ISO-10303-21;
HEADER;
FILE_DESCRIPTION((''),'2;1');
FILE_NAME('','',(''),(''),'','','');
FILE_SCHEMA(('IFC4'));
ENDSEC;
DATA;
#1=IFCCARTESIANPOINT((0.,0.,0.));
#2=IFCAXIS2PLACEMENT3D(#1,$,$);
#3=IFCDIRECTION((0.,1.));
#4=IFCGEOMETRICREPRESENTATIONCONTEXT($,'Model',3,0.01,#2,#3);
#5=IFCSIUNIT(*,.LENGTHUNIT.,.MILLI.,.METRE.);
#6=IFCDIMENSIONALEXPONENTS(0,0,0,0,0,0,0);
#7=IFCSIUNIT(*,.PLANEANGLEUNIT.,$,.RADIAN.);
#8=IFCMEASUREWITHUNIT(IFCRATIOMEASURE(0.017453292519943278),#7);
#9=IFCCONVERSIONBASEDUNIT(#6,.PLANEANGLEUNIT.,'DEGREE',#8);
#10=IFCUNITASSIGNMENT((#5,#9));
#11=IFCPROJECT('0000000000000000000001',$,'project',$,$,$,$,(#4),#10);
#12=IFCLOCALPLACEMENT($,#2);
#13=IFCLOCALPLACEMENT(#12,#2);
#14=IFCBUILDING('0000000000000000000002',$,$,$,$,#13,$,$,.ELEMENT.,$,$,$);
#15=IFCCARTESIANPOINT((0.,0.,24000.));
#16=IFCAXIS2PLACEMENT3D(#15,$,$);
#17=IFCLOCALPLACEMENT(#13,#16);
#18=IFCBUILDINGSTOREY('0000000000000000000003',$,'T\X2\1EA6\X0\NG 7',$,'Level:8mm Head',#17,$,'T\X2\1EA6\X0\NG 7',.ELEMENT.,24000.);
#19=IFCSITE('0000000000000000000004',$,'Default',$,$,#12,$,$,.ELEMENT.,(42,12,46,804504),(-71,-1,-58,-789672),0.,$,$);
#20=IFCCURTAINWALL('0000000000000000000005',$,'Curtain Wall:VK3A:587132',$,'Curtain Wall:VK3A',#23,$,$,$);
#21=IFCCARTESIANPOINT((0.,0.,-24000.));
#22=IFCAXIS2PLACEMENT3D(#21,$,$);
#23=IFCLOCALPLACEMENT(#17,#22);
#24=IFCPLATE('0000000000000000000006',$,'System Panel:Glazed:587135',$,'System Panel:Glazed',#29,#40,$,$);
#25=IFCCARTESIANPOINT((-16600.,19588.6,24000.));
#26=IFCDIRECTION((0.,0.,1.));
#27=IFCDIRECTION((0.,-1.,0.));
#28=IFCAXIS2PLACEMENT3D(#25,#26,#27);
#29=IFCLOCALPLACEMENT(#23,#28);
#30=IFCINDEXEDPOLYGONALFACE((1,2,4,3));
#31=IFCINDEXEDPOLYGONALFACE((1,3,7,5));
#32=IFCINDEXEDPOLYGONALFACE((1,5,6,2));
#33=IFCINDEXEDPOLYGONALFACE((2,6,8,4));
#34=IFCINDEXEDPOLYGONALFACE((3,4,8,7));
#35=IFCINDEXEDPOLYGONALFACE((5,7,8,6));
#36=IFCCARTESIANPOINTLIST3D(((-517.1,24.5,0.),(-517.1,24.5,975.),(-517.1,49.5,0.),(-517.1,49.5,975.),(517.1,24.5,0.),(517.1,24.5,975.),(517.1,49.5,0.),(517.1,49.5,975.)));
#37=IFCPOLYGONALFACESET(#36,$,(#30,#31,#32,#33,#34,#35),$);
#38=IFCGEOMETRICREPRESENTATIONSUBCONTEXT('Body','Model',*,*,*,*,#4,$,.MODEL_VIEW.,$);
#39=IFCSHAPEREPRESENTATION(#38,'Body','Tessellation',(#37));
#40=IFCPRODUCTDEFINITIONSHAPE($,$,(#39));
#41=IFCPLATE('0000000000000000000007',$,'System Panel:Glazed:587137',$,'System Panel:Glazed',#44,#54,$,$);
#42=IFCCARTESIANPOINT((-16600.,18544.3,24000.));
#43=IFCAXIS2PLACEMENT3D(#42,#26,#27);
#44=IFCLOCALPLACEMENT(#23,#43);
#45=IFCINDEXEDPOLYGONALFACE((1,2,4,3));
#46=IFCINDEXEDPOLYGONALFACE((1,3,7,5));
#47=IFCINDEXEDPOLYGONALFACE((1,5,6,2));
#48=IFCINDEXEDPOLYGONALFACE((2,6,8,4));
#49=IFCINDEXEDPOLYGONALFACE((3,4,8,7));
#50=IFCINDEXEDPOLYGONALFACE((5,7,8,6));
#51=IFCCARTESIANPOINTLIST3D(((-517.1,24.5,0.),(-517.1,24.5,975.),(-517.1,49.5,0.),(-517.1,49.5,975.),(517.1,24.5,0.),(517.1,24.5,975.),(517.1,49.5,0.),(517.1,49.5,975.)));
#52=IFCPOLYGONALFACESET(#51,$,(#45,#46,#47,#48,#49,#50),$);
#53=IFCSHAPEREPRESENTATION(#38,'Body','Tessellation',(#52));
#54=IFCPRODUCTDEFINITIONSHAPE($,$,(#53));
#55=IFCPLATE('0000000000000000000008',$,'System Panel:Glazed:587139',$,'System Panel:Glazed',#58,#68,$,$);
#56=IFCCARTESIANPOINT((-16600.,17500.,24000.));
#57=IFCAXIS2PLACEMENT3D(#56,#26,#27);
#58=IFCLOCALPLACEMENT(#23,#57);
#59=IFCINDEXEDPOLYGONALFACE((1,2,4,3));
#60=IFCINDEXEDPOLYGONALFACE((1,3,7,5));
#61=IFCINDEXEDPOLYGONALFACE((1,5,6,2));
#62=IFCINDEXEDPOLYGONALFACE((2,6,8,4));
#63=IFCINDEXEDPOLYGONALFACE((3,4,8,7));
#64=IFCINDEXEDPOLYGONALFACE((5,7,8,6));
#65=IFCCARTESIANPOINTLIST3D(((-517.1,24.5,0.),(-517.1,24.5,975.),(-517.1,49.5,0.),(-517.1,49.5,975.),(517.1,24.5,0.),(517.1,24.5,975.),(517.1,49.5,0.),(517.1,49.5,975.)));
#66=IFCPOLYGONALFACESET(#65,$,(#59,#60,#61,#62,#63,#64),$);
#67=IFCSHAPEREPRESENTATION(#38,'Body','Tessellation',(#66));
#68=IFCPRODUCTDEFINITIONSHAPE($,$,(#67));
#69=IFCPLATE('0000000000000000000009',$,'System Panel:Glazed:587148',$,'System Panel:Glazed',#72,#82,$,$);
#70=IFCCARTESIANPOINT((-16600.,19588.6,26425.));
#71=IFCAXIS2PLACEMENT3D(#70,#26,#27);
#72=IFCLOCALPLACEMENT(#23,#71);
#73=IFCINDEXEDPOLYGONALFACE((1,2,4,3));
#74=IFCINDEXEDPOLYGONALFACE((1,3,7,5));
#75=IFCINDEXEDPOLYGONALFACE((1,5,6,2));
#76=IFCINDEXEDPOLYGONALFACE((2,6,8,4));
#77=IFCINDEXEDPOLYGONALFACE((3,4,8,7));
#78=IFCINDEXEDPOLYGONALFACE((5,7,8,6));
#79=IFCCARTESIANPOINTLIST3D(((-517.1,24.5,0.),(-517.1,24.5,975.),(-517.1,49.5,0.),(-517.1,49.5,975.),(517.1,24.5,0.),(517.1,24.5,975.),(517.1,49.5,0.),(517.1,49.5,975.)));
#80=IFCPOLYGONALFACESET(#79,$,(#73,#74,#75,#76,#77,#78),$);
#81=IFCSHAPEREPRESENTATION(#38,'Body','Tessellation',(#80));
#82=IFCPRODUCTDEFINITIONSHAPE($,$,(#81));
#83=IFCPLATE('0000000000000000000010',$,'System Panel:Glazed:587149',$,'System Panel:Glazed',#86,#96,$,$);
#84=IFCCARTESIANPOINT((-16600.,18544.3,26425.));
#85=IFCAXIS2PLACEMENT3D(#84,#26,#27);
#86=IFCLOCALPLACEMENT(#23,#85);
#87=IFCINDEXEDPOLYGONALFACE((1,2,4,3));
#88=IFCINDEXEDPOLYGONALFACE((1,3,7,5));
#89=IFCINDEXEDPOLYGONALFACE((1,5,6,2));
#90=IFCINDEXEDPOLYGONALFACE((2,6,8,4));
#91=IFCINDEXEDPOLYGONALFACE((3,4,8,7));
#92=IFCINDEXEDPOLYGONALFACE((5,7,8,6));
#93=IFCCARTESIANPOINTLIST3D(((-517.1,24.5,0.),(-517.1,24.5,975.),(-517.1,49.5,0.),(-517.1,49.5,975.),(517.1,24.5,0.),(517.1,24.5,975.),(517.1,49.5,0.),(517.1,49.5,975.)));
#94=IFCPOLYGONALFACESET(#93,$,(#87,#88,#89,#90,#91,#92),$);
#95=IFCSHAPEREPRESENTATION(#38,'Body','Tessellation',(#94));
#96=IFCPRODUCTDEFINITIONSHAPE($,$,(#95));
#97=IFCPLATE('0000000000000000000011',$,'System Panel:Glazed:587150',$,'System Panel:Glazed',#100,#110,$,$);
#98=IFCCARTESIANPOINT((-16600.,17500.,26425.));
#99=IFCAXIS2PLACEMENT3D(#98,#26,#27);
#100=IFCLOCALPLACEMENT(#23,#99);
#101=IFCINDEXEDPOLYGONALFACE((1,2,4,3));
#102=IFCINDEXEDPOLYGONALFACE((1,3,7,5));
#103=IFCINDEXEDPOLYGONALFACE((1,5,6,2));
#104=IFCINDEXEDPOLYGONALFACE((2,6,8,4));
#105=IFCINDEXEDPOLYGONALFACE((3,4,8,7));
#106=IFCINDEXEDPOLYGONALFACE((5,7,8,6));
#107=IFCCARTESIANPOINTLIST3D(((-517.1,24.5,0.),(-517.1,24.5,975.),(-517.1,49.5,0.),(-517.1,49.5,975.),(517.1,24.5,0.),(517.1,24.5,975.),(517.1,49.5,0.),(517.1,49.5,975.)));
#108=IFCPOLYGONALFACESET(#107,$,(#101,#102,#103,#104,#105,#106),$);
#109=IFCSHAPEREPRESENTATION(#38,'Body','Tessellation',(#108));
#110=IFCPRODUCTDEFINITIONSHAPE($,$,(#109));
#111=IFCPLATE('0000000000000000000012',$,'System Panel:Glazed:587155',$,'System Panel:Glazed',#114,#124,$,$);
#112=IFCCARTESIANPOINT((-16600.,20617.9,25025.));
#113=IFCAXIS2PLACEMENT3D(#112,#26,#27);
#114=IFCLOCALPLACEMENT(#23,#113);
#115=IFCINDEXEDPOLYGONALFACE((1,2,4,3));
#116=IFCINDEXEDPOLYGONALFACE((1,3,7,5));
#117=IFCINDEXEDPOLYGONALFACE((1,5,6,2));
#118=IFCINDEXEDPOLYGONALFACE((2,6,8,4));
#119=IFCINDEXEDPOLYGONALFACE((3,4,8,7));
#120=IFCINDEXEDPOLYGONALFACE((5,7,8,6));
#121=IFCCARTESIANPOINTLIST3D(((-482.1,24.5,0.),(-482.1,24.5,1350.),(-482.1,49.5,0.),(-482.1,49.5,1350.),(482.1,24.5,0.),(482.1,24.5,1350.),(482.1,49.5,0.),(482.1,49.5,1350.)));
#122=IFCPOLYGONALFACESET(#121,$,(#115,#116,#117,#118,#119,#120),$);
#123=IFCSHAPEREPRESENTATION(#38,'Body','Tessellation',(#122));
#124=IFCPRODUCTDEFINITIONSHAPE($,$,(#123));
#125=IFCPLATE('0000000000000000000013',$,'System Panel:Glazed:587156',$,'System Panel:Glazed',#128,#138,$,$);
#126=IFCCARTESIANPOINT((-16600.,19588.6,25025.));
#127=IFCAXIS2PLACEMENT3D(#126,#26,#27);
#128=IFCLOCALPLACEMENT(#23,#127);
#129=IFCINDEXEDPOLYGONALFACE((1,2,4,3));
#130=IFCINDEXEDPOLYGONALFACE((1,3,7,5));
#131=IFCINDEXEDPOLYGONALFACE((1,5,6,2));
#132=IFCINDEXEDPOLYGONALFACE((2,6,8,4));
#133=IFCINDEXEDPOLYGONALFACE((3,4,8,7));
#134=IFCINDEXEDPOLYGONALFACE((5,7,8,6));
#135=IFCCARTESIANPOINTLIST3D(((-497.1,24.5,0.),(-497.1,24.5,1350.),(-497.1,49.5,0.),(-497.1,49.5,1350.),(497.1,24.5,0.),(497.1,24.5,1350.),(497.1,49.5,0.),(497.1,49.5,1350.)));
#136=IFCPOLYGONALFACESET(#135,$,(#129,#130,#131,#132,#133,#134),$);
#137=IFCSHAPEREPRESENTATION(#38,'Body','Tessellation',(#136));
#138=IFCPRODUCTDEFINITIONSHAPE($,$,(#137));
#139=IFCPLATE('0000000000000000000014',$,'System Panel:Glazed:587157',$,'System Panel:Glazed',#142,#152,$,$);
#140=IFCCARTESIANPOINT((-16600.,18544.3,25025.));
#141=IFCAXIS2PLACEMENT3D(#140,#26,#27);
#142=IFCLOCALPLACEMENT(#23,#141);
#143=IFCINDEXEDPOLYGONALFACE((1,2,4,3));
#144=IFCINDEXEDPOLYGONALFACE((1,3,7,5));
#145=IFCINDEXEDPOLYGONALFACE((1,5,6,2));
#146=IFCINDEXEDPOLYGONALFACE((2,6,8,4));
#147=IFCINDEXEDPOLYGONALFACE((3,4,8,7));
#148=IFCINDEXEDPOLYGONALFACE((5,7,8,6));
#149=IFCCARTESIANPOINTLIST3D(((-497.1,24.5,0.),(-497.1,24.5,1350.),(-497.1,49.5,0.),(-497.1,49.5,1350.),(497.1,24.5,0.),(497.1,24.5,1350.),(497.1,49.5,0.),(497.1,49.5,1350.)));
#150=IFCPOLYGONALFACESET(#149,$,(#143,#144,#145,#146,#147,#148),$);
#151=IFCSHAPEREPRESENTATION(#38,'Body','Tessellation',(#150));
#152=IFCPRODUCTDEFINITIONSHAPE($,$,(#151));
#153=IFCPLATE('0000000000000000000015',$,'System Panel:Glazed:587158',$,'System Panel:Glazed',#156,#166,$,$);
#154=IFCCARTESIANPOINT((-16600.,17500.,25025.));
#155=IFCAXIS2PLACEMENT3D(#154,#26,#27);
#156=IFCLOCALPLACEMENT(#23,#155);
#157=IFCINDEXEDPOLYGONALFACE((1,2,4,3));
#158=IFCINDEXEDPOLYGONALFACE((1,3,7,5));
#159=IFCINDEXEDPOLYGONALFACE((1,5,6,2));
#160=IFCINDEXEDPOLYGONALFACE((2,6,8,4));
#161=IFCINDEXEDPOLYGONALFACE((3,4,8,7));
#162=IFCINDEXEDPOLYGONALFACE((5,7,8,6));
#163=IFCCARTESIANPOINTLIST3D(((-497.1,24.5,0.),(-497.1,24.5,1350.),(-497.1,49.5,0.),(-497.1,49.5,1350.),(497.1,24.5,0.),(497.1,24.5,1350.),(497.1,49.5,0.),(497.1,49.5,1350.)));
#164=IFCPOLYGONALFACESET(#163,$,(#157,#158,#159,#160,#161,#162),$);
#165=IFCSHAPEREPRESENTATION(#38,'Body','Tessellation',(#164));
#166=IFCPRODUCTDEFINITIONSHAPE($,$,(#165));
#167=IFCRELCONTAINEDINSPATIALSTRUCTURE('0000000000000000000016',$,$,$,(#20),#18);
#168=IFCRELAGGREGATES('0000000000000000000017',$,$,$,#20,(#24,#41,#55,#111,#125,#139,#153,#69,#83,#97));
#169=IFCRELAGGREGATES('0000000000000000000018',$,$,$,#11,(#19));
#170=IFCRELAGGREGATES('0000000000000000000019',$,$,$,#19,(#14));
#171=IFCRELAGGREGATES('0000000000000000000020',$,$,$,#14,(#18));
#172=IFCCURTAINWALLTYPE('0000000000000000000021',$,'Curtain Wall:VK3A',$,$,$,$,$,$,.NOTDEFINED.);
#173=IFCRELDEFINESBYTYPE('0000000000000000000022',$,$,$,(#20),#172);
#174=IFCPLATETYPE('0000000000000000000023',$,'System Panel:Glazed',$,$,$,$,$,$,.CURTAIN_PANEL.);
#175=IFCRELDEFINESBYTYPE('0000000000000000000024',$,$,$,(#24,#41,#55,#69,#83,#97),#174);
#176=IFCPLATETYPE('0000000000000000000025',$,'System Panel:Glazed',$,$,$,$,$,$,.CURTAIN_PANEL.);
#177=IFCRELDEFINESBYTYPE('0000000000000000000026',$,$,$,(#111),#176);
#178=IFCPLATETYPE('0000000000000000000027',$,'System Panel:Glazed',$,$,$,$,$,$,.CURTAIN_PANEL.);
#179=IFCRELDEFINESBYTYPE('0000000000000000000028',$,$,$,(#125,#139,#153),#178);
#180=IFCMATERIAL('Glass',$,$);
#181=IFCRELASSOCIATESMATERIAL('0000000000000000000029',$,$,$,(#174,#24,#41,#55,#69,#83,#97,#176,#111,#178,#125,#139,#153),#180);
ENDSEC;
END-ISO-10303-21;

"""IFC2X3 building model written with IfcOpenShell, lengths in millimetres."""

from ifc_helpers import new_model, entity, si_unit, converted_unit, direction, frame, origin, origin_2d_with_axis, place, context, subcontext, project, spatial, rectangle, extrude, source, transform, mapped, material, type_object, type_shapes, element, aggregate, save


model = new_model("IFC2X3")

# Units and contexts
model_context = context("Model", 3, precision=0.01, world=origin(), true_north=direction((0.0, 1.0)))
body_context = subcontext(model_context, "Body", "Model", "MODEL_VIEW")
ifc_project = project(units=[si_unit("LENGTHUNIT", "METRE", prefix="MILLI"), converted_unit("PLANEANGLEUNIT", "DEGREE", entity("IfcRatioMeasure", 0.017453292519943278), si_unit("PLANEANGLEUNIT", "RADIAN"), dimensions=[0, 0, 0, 0, 0, 0, 0])], contexts=[model_context])

# Site, building, storey
site_placement = place(None, origin())
site = spatial("IfcSite", under=ifc_project, at=site_placement, Name="Default", CompositionType="ELEMENT", RefLatitude=(42, 12, 46, 804504), RefLongitude=(-71, -1, -58, -789672), RefElevation=0.0)
building_placement = place(site_placement, origin())
building = spatial("IfcBuilding", under=site, at=building_placement, CompositionType="ELEMENT")
storey_placement = place(building_placement, frame((0.0, 0.0, 24000.0)))
storey = spatial("IfcBuildingStorey", under=building, at=storey_placement, Name="TẦNG 7", ObjectType="Level:8mm Head", LongName="TẦNG 7", CompositionType="ELEMENT", Elevation=24000.0)

# Curtain wall
curtain_wall_type_1 = type_object("IfcCurtainWallType", Name="Curtain Wall:VK3A", PredefinedType="NOTDEFINED")
curtain_wall_1_placement = place(storey_placement, frame((0.0, 0.0, -24000.0)))
curtain_wall_1 = element("IfcCurtainWall", 1, at=curtain_wall_1_placement, inside=storey, type_object=curtain_wall_type_1, Name="Curtain Wall:VK3A:587132", ObjectType="Curtain Wall:VK3A")

# Plates
ifc_material_1 = material(Name="Glass")
plate_type_1 = type_object("IfcPlateType", Name="System Panel:Glazed", PredefinedType="CURTAIN_PANEL", material=ifc_material_1)
shared_shape_1 = source(origin(), body_context, "Body", "SweptSolid", [
    extrude(rectangle(XDim=25.0, YDim=1034.3, at=origin_2d_with_axis()), frame((0.0, 37.0, 0.0), z_axis=(0.0, 0.0, 1.0), x_axis=(0.0, 1.0, 0.0)), (0.0, 0.0, 1.0), 975.0),
])
type_shapes(plate_type_1, [shared_shape_1])
plate_1_placement = place(curtain_wall_1_placement, frame((-16600.0, 19588.6, 24000.0), z_axis=(0.0, 0.0, 1.0), x_axis=(0.0, -1.0, 0.0)))
plate_1 = element("IfcPlate", 2, at=plate_1_placement, type_object=plate_type_1, material=ifc_material_1, Name="System Panel:Glazed:587135", ObjectType="System Panel:Glazed", context=body_context, shape_type="MappedRepresentation", body=[
    mapped(shared_shape_1, transform((0.0, 0.0, 0.0), scale=1.0)),
])
plate_2_placement = place(curtain_wall_1_placement, frame((-16600.0, 18544.3, 24000.0), z_axis=(0.0, 0.0, 1.0), x_axis=(0.0, -1.0, 0.0)))
plate_2 = element("IfcPlate", 3, at=plate_2_placement, type_object=plate_type_1, material=ifc_material_1, Name="System Panel:Glazed:587137", ObjectType="System Panel:Glazed", context=body_context, shape_type="MappedRepresentation", body=[
    mapped(shared_shape_1, transform((0.0, 0.0, 0.0), scale=1.0)),
])
plate_3_placement = place(curtain_wall_1_placement, frame((-16600.0, 17500.0, 24000.0), z_axis=(0.0, 0.0, 1.0), x_axis=(0.0, -1.0, 0.0)))
plate_3 = element("IfcPlate", 4, at=plate_3_placement, type_object=plate_type_1, material=ifc_material_1, Name="System Panel:Glazed:587139", ObjectType="System Panel:Glazed", context=body_context, shape_type="MappedRepresentation", body=[
    mapped(shared_shape_1, transform((0.0, 0.0, 0.0), scale=1.0)),
])
plate_4_placement = place(curtain_wall_1_placement, frame((-16600.0, 19588.6, 26425.0), z_axis=(0.0, 0.0, 1.0), x_axis=(0.0, -1.0, 0.0)))
plate_4 = element("IfcPlate", 5, at=plate_4_placement, type_object=plate_type_1, material=ifc_material_1, Name="System Panel:Glazed:587148", ObjectType="System Panel:Glazed", context=body_context, shape_type="MappedRepresentation", body=[
    mapped(shared_shape_1, transform((0.0, 0.0, 0.0), scale=1.0)),
])
plate_5_placement = place(curtain_wall_1_placement, frame((-16600.0, 18544.3, 26425.0), z_axis=(0.0, 0.0, 1.0), x_axis=(0.0, -1.0, 0.0)))
plate_5 = element("IfcPlate", 6, at=plate_5_placement, type_object=plate_type_1, material=ifc_material_1, Name="System Panel:Glazed:587149", ObjectType="System Panel:Glazed", context=body_context, shape_type="MappedRepresentation", body=[
    mapped(shared_shape_1, transform((0.0, 0.0, 0.0), scale=1.0)),
])
plate_6_placement = place(curtain_wall_1_placement, frame((-16600.0, 17500.0, 26425.0), z_axis=(0.0, 0.0, 1.0), x_axis=(0.0, -1.0, 0.0)))
plate_6 = element("IfcPlate", 7, at=plate_6_placement, type_object=plate_type_1, material=ifc_material_1, Name="System Panel:Glazed:587150", ObjectType="System Panel:Glazed", context=body_context, shape_type="MappedRepresentation", body=[
    mapped(shared_shape_1, transform((0.0, 0.0, 0.0), scale=1.0)),
])
plate_type_2 = type_object("IfcPlateType", Name="System Panel:Glazed", PredefinedType="CURTAIN_PANEL", material=ifc_material_1)
shared_shape_2 = source(origin(), body_context, "Body", "SweptSolid", [
    extrude(rectangle(XDim=25.0, YDim=964.3, at=origin_2d_with_axis()), frame((0.0, 37.0, 0.0), z_axis=(0.0, 0.0, 1.0), x_axis=(0.0, 1.0, 0.0)), (0.0, 0.0, 1.0), 1350.0),
])
type_shapes(plate_type_2, [shared_shape_2])
plate_7_placement = place(curtain_wall_1_placement, frame((-16600.0, 20617.9, 25025.0), z_axis=(0.0, 0.0, 1.0), x_axis=(0.0, -1.0, 0.0)))
plate_7 = element("IfcPlate", 8, at=plate_7_placement, type_object=plate_type_2, material=ifc_material_1, Name="System Panel:Glazed:587155", ObjectType="System Panel:Glazed", context=body_context, shape_type="MappedRepresentation", body=[
    mapped(shared_shape_2, transform((0.0, 0.0, 0.0), scale=1.0)),
])
plate_type_3 = type_object("IfcPlateType", Name="System Panel:Glazed", PredefinedType="CURTAIN_PANEL", material=ifc_material_1)
shared_shape_3 = source(origin(), body_context, "Body", "SweptSolid", [
    extrude(rectangle(XDim=25.0, YDim=994.3, at=origin_2d_with_axis()), frame((0.0, 37.0, 0.0), z_axis=(0.0, 0.0, 1.0), x_axis=(0.0, 1.0, 0.0)), (0.0, 0.0, 1.0), 1350.0),
])
type_shapes(plate_type_3, [shared_shape_3])
plate_8_placement = place(curtain_wall_1_placement, frame((-16600.0, 19588.6, 25025.0), z_axis=(0.0, 0.0, 1.0), x_axis=(0.0, -1.0, 0.0)))
plate_8 = element("IfcPlate", 9, at=plate_8_placement, type_object=plate_type_3, material=ifc_material_1, Name="System Panel:Glazed:587156", ObjectType="System Panel:Glazed", context=body_context, shape_type="MappedRepresentation", body=[
    mapped(shared_shape_3, transform((0.0, 0.0, 0.0), scale=1.0)),
])
plate_9_placement = place(curtain_wall_1_placement, frame((-16600.0, 18544.3, 25025.0), z_axis=(0.0, 0.0, 1.0), x_axis=(0.0, -1.0, 0.0)))
plate_9 = element("IfcPlate", 10, at=plate_9_placement, type_object=plate_type_3, material=ifc_material_1, Name="System Panel:Glazed:587157", ObjectType="System Panel:Glazed", context=body_context, shape_type="MappedRepresentation", body=[
    mapped(shared_shape_3, transform((0.0, 0.0, 0.0), scale=1.0)),
])
plate_10_placement = place(curtain_wall_1_placement, frame((-16600.0, 17500.0, 25025.0), z_axis=(0.0, 0.0, 1.0), x_axis=(0.0, -1.0, 0.0)))
plate_10 = element("IfcPlate", 11, at=plate_10_placement, type_object=plate_type_3, material=ifc_material_1, Name="System Panel:Glazed:587158", ObjectType="System Panel:Glazed", context=body_context, shape_type="MappedRepresentation", body=[
    mapped(shared_shape_3, transform((0.0, 0.0, 0.0), scale=1.0)),
])
aggregate(curtain_wall_1, [plate_1, plate_2, plate_3, plate_7, plate_8, plate_9, plate_10, plate_4, plate_5, plate_6])

save(model, "model.ifc")
